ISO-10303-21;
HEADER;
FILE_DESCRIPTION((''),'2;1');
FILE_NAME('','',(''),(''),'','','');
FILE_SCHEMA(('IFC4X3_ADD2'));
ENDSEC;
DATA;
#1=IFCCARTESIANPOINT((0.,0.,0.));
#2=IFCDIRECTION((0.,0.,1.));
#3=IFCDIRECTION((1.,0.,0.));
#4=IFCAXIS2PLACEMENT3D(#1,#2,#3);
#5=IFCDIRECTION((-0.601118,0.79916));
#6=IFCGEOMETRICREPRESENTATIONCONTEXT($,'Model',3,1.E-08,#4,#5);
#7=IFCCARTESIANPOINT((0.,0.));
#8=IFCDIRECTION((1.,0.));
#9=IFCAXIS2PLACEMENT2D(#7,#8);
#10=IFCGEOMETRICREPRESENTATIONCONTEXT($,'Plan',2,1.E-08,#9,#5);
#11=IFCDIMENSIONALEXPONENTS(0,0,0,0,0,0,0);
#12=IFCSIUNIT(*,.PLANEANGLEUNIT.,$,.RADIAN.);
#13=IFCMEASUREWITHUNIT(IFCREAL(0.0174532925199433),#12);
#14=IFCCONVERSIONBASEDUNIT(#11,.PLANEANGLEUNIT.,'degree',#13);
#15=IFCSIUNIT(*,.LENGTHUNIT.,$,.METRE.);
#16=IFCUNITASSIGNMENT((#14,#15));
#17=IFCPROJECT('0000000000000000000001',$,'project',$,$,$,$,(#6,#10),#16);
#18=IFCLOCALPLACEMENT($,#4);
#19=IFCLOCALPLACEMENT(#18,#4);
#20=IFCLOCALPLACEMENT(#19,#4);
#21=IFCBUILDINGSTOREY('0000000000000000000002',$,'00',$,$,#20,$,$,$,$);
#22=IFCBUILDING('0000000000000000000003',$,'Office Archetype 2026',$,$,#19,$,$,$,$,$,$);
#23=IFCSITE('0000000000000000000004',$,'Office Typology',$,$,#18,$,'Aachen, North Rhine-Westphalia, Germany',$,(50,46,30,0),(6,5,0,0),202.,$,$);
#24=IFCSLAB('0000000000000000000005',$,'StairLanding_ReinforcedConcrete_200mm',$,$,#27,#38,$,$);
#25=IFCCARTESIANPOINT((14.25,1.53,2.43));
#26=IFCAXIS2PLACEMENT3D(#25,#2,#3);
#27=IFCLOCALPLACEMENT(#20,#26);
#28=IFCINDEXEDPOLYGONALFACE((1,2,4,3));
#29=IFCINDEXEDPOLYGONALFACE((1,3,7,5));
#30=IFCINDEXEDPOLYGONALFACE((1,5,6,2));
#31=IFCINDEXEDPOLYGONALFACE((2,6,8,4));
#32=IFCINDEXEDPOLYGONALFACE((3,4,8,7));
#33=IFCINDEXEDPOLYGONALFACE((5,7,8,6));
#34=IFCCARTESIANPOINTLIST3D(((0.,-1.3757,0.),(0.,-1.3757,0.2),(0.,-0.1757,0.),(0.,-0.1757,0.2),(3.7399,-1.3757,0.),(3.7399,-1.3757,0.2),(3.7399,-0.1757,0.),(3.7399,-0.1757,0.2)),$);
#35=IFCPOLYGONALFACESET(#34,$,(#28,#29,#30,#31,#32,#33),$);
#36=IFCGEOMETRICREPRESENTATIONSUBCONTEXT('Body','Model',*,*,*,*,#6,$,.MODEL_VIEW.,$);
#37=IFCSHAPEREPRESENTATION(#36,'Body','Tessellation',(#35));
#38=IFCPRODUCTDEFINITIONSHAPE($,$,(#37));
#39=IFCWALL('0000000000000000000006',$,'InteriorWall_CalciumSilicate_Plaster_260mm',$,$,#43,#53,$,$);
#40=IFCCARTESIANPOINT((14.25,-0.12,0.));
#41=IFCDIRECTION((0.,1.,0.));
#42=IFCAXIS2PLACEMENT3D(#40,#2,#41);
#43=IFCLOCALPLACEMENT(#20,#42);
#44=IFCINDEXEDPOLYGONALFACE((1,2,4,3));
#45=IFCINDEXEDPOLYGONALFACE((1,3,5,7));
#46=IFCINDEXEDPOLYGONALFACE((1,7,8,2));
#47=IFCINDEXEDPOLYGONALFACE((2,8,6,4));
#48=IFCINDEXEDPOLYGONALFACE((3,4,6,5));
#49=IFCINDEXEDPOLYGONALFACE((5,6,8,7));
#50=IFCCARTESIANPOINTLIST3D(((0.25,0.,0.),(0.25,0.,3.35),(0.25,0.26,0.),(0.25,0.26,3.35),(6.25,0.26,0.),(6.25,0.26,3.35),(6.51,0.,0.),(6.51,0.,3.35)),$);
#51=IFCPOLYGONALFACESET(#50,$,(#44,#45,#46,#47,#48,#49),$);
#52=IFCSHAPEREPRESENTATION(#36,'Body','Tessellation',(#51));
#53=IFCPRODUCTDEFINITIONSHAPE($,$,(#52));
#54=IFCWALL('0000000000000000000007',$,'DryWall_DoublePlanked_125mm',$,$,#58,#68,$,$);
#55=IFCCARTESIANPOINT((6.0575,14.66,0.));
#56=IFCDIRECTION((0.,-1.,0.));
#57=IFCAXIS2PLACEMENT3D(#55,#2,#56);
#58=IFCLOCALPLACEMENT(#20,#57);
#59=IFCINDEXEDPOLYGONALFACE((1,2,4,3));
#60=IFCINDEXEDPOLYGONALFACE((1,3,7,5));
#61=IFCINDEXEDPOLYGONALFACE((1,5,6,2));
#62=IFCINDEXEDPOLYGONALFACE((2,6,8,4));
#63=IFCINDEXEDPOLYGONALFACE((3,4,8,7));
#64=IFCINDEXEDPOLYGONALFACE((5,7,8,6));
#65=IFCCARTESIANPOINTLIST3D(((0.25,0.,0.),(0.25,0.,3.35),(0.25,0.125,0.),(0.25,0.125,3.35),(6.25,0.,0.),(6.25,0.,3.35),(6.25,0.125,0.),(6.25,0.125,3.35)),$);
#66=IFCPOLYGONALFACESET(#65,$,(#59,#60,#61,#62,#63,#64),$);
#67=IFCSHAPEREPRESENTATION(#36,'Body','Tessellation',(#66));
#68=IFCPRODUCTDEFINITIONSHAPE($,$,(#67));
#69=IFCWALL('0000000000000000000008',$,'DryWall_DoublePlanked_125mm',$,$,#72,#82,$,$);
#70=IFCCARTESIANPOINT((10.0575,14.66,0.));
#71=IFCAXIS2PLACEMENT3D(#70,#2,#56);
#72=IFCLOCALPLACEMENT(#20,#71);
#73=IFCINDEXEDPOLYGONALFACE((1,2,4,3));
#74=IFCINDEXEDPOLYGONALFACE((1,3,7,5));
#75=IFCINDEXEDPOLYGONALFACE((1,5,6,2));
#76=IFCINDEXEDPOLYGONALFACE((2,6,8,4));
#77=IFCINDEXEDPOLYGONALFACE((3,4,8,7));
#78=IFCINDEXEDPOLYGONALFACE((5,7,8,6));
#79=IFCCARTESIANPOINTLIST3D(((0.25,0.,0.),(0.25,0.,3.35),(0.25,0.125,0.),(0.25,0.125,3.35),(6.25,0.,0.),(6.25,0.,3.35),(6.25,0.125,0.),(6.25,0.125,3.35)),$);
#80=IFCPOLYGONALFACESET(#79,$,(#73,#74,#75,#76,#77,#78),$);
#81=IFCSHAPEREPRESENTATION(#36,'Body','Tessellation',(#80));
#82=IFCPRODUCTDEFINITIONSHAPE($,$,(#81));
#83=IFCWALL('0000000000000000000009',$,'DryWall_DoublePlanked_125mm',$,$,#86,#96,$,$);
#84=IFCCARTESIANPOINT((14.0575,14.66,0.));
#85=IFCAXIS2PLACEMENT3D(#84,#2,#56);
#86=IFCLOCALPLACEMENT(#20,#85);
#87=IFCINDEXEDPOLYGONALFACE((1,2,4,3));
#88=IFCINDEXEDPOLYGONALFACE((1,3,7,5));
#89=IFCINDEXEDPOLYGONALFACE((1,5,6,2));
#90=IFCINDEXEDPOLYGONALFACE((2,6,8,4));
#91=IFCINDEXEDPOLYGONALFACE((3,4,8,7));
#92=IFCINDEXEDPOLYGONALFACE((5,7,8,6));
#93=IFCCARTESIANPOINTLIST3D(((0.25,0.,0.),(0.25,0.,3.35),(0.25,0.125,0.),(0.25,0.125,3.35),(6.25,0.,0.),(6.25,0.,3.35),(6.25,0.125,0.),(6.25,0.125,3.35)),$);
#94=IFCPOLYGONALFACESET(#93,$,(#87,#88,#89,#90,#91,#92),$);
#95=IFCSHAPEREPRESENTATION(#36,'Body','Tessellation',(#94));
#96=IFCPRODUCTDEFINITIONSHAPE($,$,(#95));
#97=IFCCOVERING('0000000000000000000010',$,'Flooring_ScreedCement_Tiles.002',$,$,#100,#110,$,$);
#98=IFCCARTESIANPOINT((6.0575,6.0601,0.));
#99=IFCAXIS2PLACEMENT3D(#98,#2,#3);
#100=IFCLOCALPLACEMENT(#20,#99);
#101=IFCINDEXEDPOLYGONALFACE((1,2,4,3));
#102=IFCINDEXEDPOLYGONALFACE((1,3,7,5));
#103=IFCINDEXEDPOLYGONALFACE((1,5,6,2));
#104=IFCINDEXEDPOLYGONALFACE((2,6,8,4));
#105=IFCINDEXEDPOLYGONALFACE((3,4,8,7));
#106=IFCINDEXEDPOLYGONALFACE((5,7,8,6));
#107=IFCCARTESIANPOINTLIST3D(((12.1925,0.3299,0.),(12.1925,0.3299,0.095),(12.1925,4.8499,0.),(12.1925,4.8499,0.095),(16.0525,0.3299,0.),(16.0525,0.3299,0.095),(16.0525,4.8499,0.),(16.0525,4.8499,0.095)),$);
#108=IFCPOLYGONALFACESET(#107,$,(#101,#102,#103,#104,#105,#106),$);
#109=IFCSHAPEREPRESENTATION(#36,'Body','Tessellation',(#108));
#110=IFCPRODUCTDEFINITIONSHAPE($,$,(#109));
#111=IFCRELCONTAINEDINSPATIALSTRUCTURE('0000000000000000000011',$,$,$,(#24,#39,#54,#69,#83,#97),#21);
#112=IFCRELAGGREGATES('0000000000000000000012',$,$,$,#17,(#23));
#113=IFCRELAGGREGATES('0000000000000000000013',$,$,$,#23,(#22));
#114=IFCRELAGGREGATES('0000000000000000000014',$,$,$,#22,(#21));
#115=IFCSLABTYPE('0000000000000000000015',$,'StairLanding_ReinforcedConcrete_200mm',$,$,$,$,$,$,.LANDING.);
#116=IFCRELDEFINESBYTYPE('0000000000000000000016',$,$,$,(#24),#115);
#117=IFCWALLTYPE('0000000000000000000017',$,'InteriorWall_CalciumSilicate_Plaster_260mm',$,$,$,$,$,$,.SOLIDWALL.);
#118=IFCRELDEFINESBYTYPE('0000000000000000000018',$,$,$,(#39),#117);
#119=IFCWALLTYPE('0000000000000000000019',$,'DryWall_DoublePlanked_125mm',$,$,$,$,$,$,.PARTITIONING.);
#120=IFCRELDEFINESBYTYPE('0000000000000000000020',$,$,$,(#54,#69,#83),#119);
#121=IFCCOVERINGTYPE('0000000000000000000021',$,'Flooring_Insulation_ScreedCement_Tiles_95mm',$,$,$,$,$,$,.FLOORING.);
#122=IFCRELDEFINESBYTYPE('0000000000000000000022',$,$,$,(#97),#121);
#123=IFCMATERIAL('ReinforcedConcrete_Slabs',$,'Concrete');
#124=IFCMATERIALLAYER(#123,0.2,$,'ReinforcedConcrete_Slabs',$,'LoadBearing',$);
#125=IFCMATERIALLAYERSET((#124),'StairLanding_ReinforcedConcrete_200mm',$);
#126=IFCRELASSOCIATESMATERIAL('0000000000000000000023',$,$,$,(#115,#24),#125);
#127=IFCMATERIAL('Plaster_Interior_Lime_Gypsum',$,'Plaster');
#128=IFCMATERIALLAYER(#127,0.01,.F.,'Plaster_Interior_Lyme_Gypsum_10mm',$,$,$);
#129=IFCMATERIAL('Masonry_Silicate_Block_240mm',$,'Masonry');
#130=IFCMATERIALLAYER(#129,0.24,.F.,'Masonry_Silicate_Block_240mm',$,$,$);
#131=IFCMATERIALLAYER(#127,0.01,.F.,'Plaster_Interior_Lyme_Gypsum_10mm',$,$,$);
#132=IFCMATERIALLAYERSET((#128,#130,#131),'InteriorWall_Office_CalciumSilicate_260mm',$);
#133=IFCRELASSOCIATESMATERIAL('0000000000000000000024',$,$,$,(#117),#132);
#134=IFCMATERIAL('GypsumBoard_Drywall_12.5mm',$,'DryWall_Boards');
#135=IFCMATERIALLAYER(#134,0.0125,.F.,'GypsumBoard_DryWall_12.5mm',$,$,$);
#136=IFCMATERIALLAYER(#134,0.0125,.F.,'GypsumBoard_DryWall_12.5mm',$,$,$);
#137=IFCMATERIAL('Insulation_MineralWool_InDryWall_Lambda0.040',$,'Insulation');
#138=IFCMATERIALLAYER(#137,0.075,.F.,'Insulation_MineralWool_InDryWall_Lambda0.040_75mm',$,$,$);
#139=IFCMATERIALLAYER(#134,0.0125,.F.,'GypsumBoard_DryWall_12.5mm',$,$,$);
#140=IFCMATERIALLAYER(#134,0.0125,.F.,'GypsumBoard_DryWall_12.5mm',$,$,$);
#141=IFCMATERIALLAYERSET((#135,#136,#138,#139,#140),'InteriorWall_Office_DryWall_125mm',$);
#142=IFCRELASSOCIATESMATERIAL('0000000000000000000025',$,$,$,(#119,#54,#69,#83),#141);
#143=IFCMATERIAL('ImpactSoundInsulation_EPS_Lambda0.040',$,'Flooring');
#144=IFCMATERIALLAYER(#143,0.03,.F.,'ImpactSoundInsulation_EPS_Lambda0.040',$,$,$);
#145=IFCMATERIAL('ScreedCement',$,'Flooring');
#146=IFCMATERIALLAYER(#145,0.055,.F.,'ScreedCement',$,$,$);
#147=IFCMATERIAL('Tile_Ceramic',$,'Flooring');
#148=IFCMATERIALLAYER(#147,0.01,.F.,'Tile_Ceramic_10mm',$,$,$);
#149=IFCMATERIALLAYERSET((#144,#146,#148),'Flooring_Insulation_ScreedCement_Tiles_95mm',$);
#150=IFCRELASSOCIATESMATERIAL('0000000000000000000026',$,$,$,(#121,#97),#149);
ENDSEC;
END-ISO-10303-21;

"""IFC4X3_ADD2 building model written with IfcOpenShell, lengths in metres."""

from ifc_helpers import new_model, entity, si_unit, converted_unit, direction, frame, origin_with_axes, origin_2d_with_axis, place, context, subcontext, project, spatial, line, indexed_curve, outline, extrude, material, layer, layer_set, layer_usage, type_object, element, save


model = new_model("IFC4X3_ADD2")

# Units and contexts
model_context = context("Model", 3, precision=1e-08, world=origin_with_axes(), true_north=direction((-0.601118, 0.79916)))
plan_context = context("Plan", 2, precision=1e-08, world=origin_2d_with_axis(), true_north=direction((-0.601118, 0.79916)))
body_context = subcontext(model_context, "Body", "Model", "MODEL_VIEW")
ifc_project = project(units=[converted_unit("PLANEANGLEUNIT", "degree", entity("IfcReal", 0.0174532925199433), si_unit("PLANEANGLEUNIT", "RADIAN"), dimensions=[0, 0, 0, 0, 0, 0, 0]), si_unit("LENGTHUNIT", "METRE")], contexts=[model_context, plan_context])

# Site, building, storey
site_placement = place(None, origin_with_axes())
site = spatial("IfcSite", under=ifc_project, at=site_placement, Name="Office Typology", LongName="Aachen, North Rhine-Westphalia, Germany", RefLatitude=(50, 46, 30, 0), RefLongitude=(6, 5, 0, 0), RefElevation=202.0)
building_placement = place(site_placement, origin_with_axes())
building = spatial("IfcBuilding", under=site, at=building_placement, Name="Office Archetype 2026")
storey_placement = place(building_placement, origin_with_axes())
storey = spatial("IfcBuildingStorey", under=building, at=storey_placement, Name="00")

# Slab
ifc_material_1 = material(Name="ReinforcedConcrete_Slabs", Category="Concrete")
ifc_layer_1 = layer(ifc_material_1, 0.2, Name="ReinforcedConcrete_Slabs", Category="LoadBearing")
ifc_layer_set_1 = layer_set([ifc_layer_1], Name="StairLanding_ReinforcedConcrete_200mm")
ifc_layer_usage_1 = layer_usage(ifc_layer_set_1, "AXIS3", "POSITIVE", 0.0)
slab_type = type_object("IfcSlabType", Name="StairLanding_ReinforcedConcrete_200mm", PredefinedType="LANDING", material=ifc_layer_set_1)
slab_placement = place(storey_placement, frame((14.25, 1.53, 2.43), z_axis=(0.0, 0.0, 1.0), x_axis=(1.0, 0.0, 0.0)))
element("IfcSlab", 1, at=slab_placement, inside=storey, type_object=slab_type, material=ifc_layer_usage_1, Name="StairLanding_ReinforcedConcrete_200mm", context=body_context, shape_type="SweptSolid", body=[
    extrude(outline(indexed_curve([(3.7399, -0.1757), (3.7399, -1.3757), (0.0, -1.3757), (0.0, -0.1757), (3.7399, -0.1757)])), None, (0.0, 0.0, 1.0), 0.2),
])

# Shared definitions
ifc_material_2 = material(Name="Plaster_Interior_Lime_Gypsum", Category="Plaster")
ifc_layer_2 = layer(ifc_material_2, 0.01, ventilated=False, Name="Plaster_Interior_Lyme_Gypsum_10mm")
ifc_material_3 = material(Name="Masonry_Silicate_Block_240mm", Category="Masonry")
ifc_layer_3 = layer(ifc_material_3, 0.24, ventilated=False, Name="Masonry_Silicate_Block_240mm")
ifc_layer_4 = layer(ifc_material_2, 0.01, ventilated=False, Name="Plaster_Interior_Lyme_Gypsum_10mm")
ifc_layer_set_2 = layer_set([ifc_layer_2, ifc_layer_3, ifc_layer_4], Name="InteriorWall_Office_CalciumSilicate_260mm")
wall_type_1 = type_object("IfcWallType", Name="InteriorWall_CalciumSilicate_Plaster_260mm", PredefinedType="SOLIDWALL", material=ifc_layer_set_2)

# Walls
wall_1_placement = place(storey_placement, frame((14.25, -0.12, 0.0), z_axis=(0.0, 0.0, 1.0), x_axis=(0.0, 1.0, 0.0)))
element("IfcWall", 2, at=wall_1_placement, inside=storey, type_object=wall_type_1, Name="InteriorWall_CalciumSilicate_Plaster_260mm", context=body_context, shape_type="SweptSolid", body=[
    extrude(outline(indexed_curve([(0.25, 0.0), (0.25, 0.26), (6.25, 0.26), (6.51, 0.0)], segments=[line(1, 2, 3, 4, 1)])), origin_with_axes(), (0.0, 0.0, 1.0), 3.35),
])
ifc_material_4 = material(Name="GypsumBoard_Drywall_12.5mm", Category="DryWall_Boards")
ifc_layer_5 = layer(ifc_material_4, 0.0125, ventilated=False, Name="GypsumBoard_DryWall_12.5mm")
ifc_layer_6 = layer(ifc_material_4, 0.0125, ventilated=False, Name="GypsumBoard_DryWall_12.5mm")
ifc_material_5 = material(Name="Insulation_MineralWool_InDryWall_Lambda0.040", Category="Insulation")
ifc_layer_7 = layer(ifc_material_5, 0.075, ventilated=False, Name="Insulation_MineralWool_InDryWall_Lambda0.040_75mm")
ifc_layer_8 = layer(ifc_material_4, 0.0125, ventilated=False, Name="GypsumBoard_DryWall_12.5mm")
ifc_layer_9 = layer(ifc_material_4, 0.0125, ventilated=False, Name="GypsumBoard_DryWall_12.5mm")
ifc_layer_set_3 = layer_set([ifc_layer_5, ifc_layer_6, ifc_layer_7, ifc_layer_8, ifc_layer_9], Name="InteriorWall_Office_DryWall_125mm")
ifc_layer_usage_2 = layer_usage(ifc_layer_set_3, "AXIS2", "POSITIVE", 0.0)
wall_type_2 = type_object("IfcWallType", Name="DryWall_DoublePlanked_125mm", PredefinedType="PARTITIONING", material=ifc_layer_set_3)
wall_2_placement = place(storey_placement, frame((6.0575, 14.66, 0.0), z_axis=(0.0, 0.0, 1.0), x_axis=(0.0, -1.0, 0.0)))
element("IfcWall", 3, at=wall_2_placement, inside=storey, type_object=wall_type_2, material=ifc_layer_usage_2, Name="DryWall_DoublePlanked_125mm", context=body_context, shape_type="SweptSolid", body=[
    extrude(outline(indexed_curve([(0.25, 0.0), (0.25, 0.125), (6.25, 0.125), (6.25, 0.0)], segments=[line(1, 2, 3, 4, 1)])), origin_with_axes(), (0.0, 0.0, 1.0), 3.35),
])
ifc_layer_usage_3 = layer_usage(ifc_layer_set_3, "AXIS2", "POSITIVE", 0.0)
wall_3_placement = place(storey_placement, frame((10.0575, 14.66, 0.0), z_axis=(0.0, 0.0, 1.0), x_axis=(0.0, -1.0, 0.0)))
element("IfcWall", 4, at=wall_3_placement, inside=storey, type_object=wall_type_2, material=ifc_layer_usage_3, Name="DryWall_DoublePlanked_125mm", context=body_context, shape_type="SweptSolid", body=[
    extrude(outline(indexed_curve([(0.25, 0.0), (0.25, 0.125), (6.25, 0.125), (6.25, 0.0)], segments=[line(1, 2, 3, 4, 1)])), origin_with_axes(), (0.0, 0.0, 1.0), 3.35),
])
ifc_layer_usage_4 = layer_usage(ifc_layer_set_3, "AXIS2", "POSITIVE", 0.0)
wall_4_placement = place(storey_placement, frame((14.0575, 14.66, 0.0), z_axis=(0.0, 0.0, 1.0), x_axis=(0.0, -1.0, 0.0)))
element("IfcWall", 5, at=wall_4_placement, inside=storey, type_object=wall_type_2, material=ifc_layer_usage_4, Name="DryWall_DoublePlanked_125mm", context=body_context, shape_type="SweptSolid", body=[
    extrude(outline(indexed_curve([(0.25, 0.0), (0.25, 0.125), (6.25, 0.125), (6.25, 0.0)], segments=[line(1, 2, 3, 4, 1)])), origin_with_axes(), (0.0, 0.0, 1.0), 3.35),
])

# Covering
ifc_material_6 = material(Name="ImpactSoundInsulation_EPS_Lambda0.040", Category="Flooring")
ifc_layer_10 = layer(ifc_material_6, 0.03, ventilated=False, Name="ImpactSoundInsulation_EPS_Lambda0.040")
ifc_material_7 = material(Name="ScreedCement", Category="Flooring")
ifc_layer_11 = layer(ifc_material_7, 0.055, ventilated=False, Name="ScreedCement")
ifc_material_8 = material(Name="Tile_Ceramic", Category="Flooring")
ifc_layer_12 = layer(ifc_material_8, 0.01, ventilated=False, Name="Tile_Ceramic_10mm")
ifc_layer_set_4 = layer_set([ifc_layer_10, ifc_layer_11, ifc_layer_12], Name="Flooring_Insulation_ScreedCement_Tiles_95mm")
ifc_layer_usage_5 = layer_usage(ifc_layer_set_4, "AXIS3", "POSITIVE", 0.0)
covering_type = type_object("IfcCoveringType", Name="Flooring_Insulation_ScreedCement_Tiles_95mm", PredefinedType="FLOORING", material=ifc_layer_set_4)
covering_placement = place(storey_placement, frame((6.0575, 6.0601, 0.0), z_axis=(0.0, 0.0, 1.0), x_axis=(1.0, 0.0, 0.0)))
element("IfcCovering", 6, at=covering_placement, inside=storey, type_object=covering_type, material=ifc_layer_usage_5, Name="Flooring_ScreedCement_Tiles.002", context=body_context, shape_type="SweptSolid", body=[
    extrude(outline(indexed_curve([(12.1925, 0.3299), (12.1925, 4.8499), (16.0525, 4.8499), (16.0525, 0.3299)], segments=[line(1, 2, 3, 4, 1)])), origin_with_axes(), (0.0, 0.0, 1.0), 0.095),
])

save(model, "model.ifc")
